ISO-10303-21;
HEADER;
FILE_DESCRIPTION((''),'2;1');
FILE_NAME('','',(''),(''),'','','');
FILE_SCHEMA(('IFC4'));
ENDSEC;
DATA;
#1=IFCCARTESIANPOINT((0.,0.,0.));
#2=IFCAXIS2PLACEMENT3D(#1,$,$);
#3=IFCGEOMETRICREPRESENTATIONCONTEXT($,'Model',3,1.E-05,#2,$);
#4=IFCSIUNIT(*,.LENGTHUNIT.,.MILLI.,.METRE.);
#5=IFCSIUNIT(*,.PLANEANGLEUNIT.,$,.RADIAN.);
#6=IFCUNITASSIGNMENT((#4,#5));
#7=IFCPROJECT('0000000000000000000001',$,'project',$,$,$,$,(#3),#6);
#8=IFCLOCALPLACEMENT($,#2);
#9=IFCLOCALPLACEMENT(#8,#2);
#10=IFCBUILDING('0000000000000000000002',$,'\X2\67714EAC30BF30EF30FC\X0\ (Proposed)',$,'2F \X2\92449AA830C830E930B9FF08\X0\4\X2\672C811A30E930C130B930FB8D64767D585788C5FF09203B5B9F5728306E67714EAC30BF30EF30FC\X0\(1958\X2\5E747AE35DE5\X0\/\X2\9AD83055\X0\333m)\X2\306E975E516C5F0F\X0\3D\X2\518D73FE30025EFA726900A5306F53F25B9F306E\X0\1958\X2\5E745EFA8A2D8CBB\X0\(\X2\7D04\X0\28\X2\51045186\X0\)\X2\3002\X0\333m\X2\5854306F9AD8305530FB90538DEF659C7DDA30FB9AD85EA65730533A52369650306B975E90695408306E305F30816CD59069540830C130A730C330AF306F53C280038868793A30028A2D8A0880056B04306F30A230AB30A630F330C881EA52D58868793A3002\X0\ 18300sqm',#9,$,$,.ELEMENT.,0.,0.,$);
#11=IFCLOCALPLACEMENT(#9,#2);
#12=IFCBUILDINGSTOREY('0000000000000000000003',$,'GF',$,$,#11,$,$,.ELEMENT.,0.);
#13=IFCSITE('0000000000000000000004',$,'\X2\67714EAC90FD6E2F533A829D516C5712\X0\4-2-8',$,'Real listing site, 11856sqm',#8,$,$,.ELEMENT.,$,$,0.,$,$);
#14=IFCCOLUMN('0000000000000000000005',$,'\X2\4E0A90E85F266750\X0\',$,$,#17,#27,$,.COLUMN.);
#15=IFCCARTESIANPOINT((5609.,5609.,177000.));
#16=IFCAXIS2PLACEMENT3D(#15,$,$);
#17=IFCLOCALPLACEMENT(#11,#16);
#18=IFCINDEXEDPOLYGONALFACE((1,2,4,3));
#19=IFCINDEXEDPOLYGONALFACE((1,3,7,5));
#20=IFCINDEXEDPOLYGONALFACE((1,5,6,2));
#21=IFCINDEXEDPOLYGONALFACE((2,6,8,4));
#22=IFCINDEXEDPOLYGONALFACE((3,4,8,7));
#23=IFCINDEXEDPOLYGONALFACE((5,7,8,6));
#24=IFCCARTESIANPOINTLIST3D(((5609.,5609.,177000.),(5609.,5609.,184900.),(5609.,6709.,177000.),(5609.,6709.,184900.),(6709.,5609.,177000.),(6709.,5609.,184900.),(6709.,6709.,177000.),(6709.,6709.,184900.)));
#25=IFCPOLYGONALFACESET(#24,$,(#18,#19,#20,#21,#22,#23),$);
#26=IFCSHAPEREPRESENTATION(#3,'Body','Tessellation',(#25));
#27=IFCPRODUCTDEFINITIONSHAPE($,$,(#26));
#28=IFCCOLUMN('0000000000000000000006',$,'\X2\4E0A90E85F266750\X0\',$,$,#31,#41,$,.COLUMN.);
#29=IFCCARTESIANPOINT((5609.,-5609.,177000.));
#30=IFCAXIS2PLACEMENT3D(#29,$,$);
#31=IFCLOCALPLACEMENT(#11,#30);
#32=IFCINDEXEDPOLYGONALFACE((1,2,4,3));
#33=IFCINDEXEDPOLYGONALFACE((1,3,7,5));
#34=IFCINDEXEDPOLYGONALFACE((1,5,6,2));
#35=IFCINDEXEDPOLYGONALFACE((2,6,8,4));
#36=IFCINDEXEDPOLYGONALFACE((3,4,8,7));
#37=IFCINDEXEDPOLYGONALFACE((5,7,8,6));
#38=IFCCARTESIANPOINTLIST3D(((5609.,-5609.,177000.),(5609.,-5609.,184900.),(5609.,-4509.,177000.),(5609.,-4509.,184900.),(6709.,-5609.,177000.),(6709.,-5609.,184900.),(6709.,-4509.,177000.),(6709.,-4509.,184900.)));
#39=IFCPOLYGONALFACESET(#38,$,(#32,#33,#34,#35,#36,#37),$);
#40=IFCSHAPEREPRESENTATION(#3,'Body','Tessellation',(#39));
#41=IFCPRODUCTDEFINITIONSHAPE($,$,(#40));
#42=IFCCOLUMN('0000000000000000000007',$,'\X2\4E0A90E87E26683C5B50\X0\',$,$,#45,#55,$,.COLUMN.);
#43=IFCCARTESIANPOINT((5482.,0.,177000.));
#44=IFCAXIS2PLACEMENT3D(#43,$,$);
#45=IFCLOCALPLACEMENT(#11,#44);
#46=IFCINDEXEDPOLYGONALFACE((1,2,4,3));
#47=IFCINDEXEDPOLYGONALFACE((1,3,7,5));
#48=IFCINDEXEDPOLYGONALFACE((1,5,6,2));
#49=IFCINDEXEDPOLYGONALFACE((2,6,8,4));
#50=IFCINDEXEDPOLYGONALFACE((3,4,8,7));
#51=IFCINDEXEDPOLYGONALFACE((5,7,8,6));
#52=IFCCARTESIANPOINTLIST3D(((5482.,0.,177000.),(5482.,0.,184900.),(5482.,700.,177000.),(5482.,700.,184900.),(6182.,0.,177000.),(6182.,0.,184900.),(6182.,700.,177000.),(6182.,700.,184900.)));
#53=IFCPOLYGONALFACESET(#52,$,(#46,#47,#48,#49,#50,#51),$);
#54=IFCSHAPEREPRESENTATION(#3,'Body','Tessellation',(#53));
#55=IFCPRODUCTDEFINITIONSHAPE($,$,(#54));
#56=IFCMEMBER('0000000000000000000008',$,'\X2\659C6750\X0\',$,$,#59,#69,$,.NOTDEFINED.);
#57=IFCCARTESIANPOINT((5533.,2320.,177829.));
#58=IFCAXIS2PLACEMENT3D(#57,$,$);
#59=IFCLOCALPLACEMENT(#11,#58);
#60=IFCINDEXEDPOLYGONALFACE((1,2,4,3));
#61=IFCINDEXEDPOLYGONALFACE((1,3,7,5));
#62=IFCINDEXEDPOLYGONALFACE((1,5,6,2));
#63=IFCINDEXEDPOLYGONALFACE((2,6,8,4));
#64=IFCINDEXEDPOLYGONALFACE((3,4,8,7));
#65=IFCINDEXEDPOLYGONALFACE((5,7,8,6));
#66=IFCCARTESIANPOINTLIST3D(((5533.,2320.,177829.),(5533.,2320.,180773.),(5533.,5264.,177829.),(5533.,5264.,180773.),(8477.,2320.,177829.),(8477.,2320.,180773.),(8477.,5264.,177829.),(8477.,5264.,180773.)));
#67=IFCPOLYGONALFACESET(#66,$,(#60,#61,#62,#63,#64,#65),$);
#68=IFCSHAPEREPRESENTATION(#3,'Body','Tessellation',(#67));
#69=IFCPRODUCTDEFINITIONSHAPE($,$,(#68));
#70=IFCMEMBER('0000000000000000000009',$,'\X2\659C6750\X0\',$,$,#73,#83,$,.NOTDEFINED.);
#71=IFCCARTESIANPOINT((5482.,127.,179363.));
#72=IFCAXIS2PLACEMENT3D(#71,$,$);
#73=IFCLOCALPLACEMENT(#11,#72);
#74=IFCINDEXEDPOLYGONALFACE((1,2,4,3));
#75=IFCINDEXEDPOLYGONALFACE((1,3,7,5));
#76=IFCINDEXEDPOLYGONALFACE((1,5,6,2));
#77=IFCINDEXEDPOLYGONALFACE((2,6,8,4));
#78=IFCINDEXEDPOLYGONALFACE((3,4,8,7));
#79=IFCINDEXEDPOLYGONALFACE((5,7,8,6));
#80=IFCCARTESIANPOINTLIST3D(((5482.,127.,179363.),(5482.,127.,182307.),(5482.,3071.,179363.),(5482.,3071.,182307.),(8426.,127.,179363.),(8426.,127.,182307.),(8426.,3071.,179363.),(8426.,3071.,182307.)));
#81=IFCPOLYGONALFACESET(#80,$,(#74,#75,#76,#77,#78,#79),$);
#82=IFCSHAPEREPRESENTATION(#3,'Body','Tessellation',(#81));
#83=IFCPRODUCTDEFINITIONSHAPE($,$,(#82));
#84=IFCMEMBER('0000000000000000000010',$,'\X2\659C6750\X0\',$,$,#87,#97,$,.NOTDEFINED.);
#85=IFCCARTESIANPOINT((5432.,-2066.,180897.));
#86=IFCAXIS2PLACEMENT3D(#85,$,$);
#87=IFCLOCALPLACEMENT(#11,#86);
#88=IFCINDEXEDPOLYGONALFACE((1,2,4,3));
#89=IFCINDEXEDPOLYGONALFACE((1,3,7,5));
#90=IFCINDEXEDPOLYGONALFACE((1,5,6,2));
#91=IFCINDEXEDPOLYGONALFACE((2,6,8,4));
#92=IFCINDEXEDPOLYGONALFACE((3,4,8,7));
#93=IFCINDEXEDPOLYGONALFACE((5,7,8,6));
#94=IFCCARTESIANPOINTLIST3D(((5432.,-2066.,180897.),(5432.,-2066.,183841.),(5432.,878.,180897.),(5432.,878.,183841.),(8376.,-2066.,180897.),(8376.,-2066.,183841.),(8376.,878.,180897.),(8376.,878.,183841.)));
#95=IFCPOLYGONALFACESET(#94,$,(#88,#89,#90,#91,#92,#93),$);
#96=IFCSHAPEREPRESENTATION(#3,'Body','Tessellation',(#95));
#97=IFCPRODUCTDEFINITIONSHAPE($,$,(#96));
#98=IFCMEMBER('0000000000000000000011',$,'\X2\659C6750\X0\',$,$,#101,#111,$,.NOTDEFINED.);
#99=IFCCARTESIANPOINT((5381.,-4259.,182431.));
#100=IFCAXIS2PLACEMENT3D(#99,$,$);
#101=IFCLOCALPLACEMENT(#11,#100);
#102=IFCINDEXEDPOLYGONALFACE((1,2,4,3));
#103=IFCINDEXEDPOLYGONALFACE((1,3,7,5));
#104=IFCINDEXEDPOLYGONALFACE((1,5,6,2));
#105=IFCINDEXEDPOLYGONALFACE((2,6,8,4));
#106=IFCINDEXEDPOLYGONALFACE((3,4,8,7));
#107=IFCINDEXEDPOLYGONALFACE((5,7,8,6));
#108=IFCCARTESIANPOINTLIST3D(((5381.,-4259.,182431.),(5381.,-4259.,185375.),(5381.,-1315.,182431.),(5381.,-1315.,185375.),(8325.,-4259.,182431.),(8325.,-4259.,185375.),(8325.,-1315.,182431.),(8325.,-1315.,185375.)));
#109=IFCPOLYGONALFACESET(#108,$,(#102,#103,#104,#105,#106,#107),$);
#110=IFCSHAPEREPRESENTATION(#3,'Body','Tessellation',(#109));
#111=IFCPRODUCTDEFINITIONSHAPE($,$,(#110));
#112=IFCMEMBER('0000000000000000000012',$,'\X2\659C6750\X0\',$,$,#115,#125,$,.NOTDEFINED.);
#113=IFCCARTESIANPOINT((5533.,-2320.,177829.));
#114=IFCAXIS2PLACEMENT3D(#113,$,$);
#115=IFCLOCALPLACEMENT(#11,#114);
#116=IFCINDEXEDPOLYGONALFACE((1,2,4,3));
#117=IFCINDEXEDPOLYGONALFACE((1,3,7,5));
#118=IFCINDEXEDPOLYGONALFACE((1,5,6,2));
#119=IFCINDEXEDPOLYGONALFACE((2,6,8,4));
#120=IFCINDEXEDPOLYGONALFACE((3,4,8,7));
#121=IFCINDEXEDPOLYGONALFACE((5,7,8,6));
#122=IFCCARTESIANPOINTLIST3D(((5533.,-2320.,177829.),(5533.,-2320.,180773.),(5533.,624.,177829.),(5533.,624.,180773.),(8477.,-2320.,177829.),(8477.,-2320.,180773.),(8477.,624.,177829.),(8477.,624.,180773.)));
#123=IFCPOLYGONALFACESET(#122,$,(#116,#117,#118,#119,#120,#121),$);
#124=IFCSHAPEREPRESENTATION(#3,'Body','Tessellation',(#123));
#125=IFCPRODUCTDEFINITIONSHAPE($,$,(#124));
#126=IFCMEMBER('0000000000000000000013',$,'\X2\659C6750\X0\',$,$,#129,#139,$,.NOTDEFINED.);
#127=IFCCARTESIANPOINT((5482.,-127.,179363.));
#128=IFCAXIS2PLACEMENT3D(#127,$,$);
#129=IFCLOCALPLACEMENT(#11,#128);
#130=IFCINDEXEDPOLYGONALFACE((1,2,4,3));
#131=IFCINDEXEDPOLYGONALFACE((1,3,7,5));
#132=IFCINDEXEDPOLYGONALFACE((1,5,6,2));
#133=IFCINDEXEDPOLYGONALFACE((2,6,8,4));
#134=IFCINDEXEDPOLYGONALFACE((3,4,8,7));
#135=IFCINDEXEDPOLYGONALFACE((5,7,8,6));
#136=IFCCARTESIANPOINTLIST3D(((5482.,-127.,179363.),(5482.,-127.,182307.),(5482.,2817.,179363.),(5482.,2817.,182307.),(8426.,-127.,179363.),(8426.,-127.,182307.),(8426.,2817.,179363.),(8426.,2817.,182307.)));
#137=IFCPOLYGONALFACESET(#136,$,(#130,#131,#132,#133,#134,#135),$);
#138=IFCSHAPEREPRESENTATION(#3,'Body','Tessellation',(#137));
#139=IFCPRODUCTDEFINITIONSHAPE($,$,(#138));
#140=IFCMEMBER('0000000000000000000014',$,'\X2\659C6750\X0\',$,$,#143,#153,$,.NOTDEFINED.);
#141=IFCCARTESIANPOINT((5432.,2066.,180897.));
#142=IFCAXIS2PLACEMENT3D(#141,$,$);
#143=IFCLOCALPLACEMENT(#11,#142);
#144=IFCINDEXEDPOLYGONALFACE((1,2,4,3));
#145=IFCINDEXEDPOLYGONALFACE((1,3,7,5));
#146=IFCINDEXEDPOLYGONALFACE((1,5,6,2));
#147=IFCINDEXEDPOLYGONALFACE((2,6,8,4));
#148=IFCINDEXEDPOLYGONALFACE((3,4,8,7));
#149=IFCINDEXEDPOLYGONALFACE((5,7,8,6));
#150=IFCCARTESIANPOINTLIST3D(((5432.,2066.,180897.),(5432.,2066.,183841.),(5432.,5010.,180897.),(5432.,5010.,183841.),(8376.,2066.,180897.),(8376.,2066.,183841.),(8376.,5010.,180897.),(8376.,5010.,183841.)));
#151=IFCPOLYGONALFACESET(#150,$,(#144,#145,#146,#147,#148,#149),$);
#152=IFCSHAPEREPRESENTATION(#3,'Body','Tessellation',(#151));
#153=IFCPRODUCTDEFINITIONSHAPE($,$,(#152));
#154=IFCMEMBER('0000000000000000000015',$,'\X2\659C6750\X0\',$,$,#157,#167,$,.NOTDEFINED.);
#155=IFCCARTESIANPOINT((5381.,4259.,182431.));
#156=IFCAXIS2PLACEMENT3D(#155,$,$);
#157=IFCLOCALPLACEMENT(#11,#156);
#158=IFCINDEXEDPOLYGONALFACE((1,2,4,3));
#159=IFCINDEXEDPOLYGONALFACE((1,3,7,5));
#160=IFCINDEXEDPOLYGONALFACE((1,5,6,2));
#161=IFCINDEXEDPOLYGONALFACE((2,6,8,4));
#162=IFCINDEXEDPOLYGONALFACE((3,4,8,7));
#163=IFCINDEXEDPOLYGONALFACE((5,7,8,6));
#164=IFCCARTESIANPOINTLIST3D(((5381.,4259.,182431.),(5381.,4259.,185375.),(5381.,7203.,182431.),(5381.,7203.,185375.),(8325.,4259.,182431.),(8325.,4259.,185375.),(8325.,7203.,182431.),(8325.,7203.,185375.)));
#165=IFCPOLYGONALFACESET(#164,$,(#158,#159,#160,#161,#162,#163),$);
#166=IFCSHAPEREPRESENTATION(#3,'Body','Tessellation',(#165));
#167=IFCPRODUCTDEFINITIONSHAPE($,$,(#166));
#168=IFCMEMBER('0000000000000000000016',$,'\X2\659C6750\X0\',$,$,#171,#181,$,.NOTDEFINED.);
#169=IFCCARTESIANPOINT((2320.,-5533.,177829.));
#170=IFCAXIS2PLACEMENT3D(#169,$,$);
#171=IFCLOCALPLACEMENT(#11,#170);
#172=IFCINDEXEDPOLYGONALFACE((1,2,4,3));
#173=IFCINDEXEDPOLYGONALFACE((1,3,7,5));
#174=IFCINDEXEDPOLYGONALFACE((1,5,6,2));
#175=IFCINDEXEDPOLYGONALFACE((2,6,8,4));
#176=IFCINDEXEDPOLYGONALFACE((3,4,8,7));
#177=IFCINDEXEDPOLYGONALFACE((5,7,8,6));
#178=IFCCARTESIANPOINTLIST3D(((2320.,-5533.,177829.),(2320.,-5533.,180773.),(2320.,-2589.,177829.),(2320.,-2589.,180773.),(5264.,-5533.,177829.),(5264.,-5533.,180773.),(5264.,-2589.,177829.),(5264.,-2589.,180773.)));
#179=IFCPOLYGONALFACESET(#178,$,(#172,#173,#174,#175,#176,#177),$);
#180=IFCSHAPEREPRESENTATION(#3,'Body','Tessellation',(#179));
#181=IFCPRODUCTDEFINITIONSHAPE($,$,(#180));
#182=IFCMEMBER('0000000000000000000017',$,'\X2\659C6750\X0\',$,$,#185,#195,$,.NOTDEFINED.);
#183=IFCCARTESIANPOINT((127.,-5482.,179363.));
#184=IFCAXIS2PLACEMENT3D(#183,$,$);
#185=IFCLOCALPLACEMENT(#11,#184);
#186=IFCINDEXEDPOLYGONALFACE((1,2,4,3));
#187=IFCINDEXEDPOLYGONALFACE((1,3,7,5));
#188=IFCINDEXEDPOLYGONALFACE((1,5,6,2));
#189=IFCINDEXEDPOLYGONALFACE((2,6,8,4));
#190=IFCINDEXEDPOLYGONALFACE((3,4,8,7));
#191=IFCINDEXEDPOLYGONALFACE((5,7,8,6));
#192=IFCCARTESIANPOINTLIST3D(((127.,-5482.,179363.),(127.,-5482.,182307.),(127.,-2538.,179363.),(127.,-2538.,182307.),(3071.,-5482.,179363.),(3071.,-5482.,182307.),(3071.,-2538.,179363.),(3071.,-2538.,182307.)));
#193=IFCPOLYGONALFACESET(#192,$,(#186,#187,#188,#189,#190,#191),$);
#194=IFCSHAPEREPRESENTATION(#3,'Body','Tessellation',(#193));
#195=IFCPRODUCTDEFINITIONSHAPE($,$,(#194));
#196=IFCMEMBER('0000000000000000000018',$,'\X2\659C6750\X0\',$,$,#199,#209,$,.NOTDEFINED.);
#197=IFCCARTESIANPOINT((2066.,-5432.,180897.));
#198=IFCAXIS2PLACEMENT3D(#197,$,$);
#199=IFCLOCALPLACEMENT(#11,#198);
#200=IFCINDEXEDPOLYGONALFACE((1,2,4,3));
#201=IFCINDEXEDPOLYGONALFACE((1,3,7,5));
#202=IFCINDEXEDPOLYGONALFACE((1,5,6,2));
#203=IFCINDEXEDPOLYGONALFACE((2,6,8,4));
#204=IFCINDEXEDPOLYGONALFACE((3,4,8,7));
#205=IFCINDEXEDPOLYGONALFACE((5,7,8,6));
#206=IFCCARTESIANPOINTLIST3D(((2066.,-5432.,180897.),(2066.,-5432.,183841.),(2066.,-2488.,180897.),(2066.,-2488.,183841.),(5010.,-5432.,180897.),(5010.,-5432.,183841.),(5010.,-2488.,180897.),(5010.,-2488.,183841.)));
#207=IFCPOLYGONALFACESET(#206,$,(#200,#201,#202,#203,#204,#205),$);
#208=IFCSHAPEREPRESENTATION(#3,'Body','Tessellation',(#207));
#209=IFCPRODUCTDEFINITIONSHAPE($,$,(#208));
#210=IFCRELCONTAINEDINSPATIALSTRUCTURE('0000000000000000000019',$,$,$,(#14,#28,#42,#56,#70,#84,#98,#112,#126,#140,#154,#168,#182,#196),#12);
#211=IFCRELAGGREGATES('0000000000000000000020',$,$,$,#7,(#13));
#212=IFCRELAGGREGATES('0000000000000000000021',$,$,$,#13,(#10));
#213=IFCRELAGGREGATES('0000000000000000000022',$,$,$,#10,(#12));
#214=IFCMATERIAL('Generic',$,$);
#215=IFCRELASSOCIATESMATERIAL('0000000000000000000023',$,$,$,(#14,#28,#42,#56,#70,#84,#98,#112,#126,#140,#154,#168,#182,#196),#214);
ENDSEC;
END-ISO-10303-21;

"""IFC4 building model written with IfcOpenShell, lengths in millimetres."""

from ifc_helpers import new_model, si_unit, frame, frame_2d, origin, place, context, project, spatial, rectangle, extrude, material, element, save


model = new_model("IFC4")

# Units and contexts
model_context = context("Model", 3, precision=1e-05, world=origin())
ifc_project = project(units=[si_unit("LENGTHUNIT", "METRE", prefix="MILLI"), si_unit("PLANEANGLEUNIT", "RADIAN")], contexts=[model_context])

# Site, building, storey
site_placement = place(None, origin())
site = spatial("IfcSite", under=ifc_project, at=site_placement, Name="東京都港区芝公園4-2-8", ObjectType="Real listing site, 11856sqm", CompositionType="ELEMENT", RefElevation=0.0)
building_placement = place(site_placement, origin())
building = spatial("IfcBuilding", under=site, at=building_placement, Name="東京タワー (Proposed)", ObjectType="2F 鉄骨トラス（4本脚ラチス・赤白塗装）※実在の東京タワー(1958年竣工/高さ333m)の非公式3D再現。建物¥は史実の1958年建設費(約28億円)。333m塔は高さ・道路斜線・高度地区制限に非適合のため法適合チェックは参考表示。設計者欄はアカウント自動表示。 18300sqm", CompositionType="ELEMENT", ElevationOfRefHeight=0.0, ElevationOfTerrain=0.0)
storey_placement = place(building_placement, origin())
storey = spatial("IfcBuildingStorey", under=building, at=storey_placement, Name="GF", CompositionType="ELEMENT", Elevation=0.0)

# Columns
ifc_material = material(Name="Generic")
column_1_placement = place(storey_placement, frame((5609.0, 5609.0, 177000.0)))
element("IfcColumn", 1, at=column_1_placement, inside=storey, material=ifc_material, Name="上部弦材", PredefinedType="COLUMN", context=model_context, shape_type="SweptSolid", body=[
    extrude(rectangle(XDim=1100.0, YDim=1100.0, at=frame_2d((550.0, 550.0))), frame((5609.0, 5609.0, 177000.0)), (0.0, 0.0, 1.0), 7900.0),
])
column_2_placement = place(storey_placement, frame((5609.0, -5609.0, 177000.0)))
element("IfcColumn", 2, at=column_2_placement, inside=storey, material=ifc_material, Name="上部弦材", PredefinedType="COLUMN", context=model_context, shape_type="SweptSolid", body=[
    extrude(rectangle(XDim=1100.0, YDim=1100.0, at=frame_2d((550.0, 550.0))), frame((5609.0, -5609.0, 177000.0)), (0.0, 0.0, 1.0), 7900.0),
])
column_3_placement = place(storey_placement, frame((5482.0, 0.0, 177000.0)))
element("IfcColumn", 3, at=column_3_placement, inside=storey, material=ifc_material, Name="上部縦格子", PredefinedType="COLUMN", context=model_context, shape_type="SweptSolid", body=[
    extrude(rectangle(XDim=700.0, YDim=700.0, at=frame_2d((350.0, 350.0))), frame((5482.0, 0.0, 177000.0)), (0.0, 0.0, 1.0), 7900.0),
])

# Members
member_1_placement = place(storey_placement, frame((5533.0, 2320.0, 177829.0)))
element("IfcMember", 4, at=member_1_placement, inside=storey, material=ifc_material, Name="斜材", PredefinedType="NOTDEFINED", context=model_context, shape_type="SweptSolid", body=[
    extrude(rectangle(XDim=2944.0, YDim=2944.0, at=frame_2d((1472.0, 1472.0))), frame((5533.0, 2320.0, 177829.0)), (0.0, 0.0, 1.0), 2944.0),
])
member_2_placement = place(storey_placement, frame((5482.0, 127.0, 179363.0)))
element("IfcMember", 5, at=member_2_placement, inside=storey, material=ifc_material, Name="斜材", PredefinedType="NOTDEFINED", context=model_context, shape_type="SweptSolid", body=[
    extrude(rectangle(XDim=2944.0, YDim=2944.0, at=frame_2d((1472.0, 1472.0))), frame((5482.0, 127.0, 179363.0)), (0.0, 0.0, 1.0), 2944.0),
])
member_3_placement = place(storey_placement, frame((5432.0, -2066.0, 180897.0)))
element("IfcMember", 6, at=member_3_placement, inside=storey, material=ifc_material, Name="斜材", PredefinedType="NOTDEFINED", context=model_context, shape_type="SweptSolid", body=[
    extrude(rectangle(XDim=2944.0, YDim=2944.0, at=frame_2d((1472.0, 1472.0))), frame((5432.0, -2066.0, 180897.0)), (0.0, 0.0, 1.0), 2944.0),
])
member_4_placement = place(storey_placement, frame((5381.0, -4259.0, 182431.0)))
element("IfcMember", 7, at=member_4_placement, inside=storey, material=ifc_material, Name="斜材", PredefinedType="NOTDEFINED", context=model_context, shape_type="SweptSolid", body=[
    extrude(rectangle(XDim=2944.0, YDim=2944.0, at=frame_2d((1472.0, 1472.0))), frame((5381.0, -4259.0, 182431.0)), (0.0, 0.0, 1.0), 2944.0),
])
member_5_placement = place(storey_placement, frame((5533.0, -2320.0, 177829.0)))
element("IfcMember", 8, at=member_5_placement, inside=storey, material=ifc_material, Name="斜材", PredefinedType="NOTDEFINED", context=model_context, shape_type="SweptSolid", body=[
    extrude(rectangle(XDim=2944.0, YDim=2944.0, at=frame_2d((1472.0, 1472.0))), frame((5533.0, -2320.0, 177829.0)), (0.0, 0.0, 1.0), 2944.0),
])
member_6_placement = place(storey_placement, frame((5482.0, -127.0, 179363.0)))
element("IfcMember", 9, at=member_6_placement, inside=storey, material=ifc_material, Name="斜材", PredefinedType="NOTDEFINED", context=model_context, shape_type="SweptSolid", body=[
    extrude(rectangle(XDim=2944.0, YDim=2944.0, at=frame_2d((1472.0, 1472.0))), frame((5482.0, -127.0, 179363.0)), (0.0, 0.0, 1.0), 2944.0),
])
member_7_placement = place(storey_placement, frame((5432.0, 2066.0, 180897.0)))
element("IfcMember", 10, at=member_7_placement, inside=storey, material=ifc_material, Name="斜材", PredefinedType="NOTDEFINED", context=model_context, shape_type="SweptSolid", body=[
    extrude(rectangle(XDim=2944.0, YDim=2944.0, at=frame_2d((1472.0, 1472.0))), frame((5432.0, 2066.0, 180897.0)), (0.0, 0.0, 1.0), 2944.0),
])
member_8_placement = place(storey_placement, frame((5381.0, 4259.0, 182431.0)))
element("IfcMember", 11, at=member_8_placement, inside=storey, material=ifc_material, Name="斜材", PredefinedType="NOTDEFINED", context=model_context, shape_type="SweptSolid", body=[
    extrude(rectangle(XDim=2944.0, YDim=2944.0, at=frame_2d((1472.0, 1472.0))), frame((5381.0, 4259.0, 182431.0)), (0.0, 0.0, 1.0), 2944.0),
])
member_9_placement = place(storey_placement, frame((2320.0, -5533.0, 177829.0)))
element("IfcMember", 12, at=member_9_placement, inside=storey, material=ifc_material, Name="斜材", PredefinedType="NOTDEFINED", context=model_context, shape_type="SweptSolid", body=[
    extrude(rectangle(XDim=2944.0, YDim=2944.0, at=frame_2d((1472.0, 1472.0))), frame((2320.0, -5533.0, 177829.0)), (0.0, 0.0, 1.0), 2944.0),
])
member_10_placement = place(storey_placement, frame((127.0, -5482.0, 179363.0)))
element("IfcMember", 13, at=member_10_placement, inside=storey, material=ifc_material, Name="斜材", PredefinedType="NOTDEFINED", context=model_context, shape_type="SweptSolid", body=[
    extrude(rectangle(XDim=2944.0, YDim=2944.0, at=frame_2d((1472.0, 1472.0))), frame((127.0, -5482.0, 179363.0)), (0.0, 0.0, 1.0), 2944.0),
])
member_11_placement = place(storey_placement, frame((2066.0, -5432.0, 180897.0)))
element("IfcMember", 14, at=member_11_placement, inside=storey, material=ifc_material, Name="斜材", PredefinedType="NOTDEFINED", context=model_context, shape_type="SweptSolid", body=[
    extrude(rectangle(XDim=2944.0, YDim=2944.0, at=frame_2d((1472.0, 1472.0))), frame((2066.0, -5432.0, 180897.0)), (0.0, 0.0, 1.0), 2944.0),
])

save(model, "model.ifc")
